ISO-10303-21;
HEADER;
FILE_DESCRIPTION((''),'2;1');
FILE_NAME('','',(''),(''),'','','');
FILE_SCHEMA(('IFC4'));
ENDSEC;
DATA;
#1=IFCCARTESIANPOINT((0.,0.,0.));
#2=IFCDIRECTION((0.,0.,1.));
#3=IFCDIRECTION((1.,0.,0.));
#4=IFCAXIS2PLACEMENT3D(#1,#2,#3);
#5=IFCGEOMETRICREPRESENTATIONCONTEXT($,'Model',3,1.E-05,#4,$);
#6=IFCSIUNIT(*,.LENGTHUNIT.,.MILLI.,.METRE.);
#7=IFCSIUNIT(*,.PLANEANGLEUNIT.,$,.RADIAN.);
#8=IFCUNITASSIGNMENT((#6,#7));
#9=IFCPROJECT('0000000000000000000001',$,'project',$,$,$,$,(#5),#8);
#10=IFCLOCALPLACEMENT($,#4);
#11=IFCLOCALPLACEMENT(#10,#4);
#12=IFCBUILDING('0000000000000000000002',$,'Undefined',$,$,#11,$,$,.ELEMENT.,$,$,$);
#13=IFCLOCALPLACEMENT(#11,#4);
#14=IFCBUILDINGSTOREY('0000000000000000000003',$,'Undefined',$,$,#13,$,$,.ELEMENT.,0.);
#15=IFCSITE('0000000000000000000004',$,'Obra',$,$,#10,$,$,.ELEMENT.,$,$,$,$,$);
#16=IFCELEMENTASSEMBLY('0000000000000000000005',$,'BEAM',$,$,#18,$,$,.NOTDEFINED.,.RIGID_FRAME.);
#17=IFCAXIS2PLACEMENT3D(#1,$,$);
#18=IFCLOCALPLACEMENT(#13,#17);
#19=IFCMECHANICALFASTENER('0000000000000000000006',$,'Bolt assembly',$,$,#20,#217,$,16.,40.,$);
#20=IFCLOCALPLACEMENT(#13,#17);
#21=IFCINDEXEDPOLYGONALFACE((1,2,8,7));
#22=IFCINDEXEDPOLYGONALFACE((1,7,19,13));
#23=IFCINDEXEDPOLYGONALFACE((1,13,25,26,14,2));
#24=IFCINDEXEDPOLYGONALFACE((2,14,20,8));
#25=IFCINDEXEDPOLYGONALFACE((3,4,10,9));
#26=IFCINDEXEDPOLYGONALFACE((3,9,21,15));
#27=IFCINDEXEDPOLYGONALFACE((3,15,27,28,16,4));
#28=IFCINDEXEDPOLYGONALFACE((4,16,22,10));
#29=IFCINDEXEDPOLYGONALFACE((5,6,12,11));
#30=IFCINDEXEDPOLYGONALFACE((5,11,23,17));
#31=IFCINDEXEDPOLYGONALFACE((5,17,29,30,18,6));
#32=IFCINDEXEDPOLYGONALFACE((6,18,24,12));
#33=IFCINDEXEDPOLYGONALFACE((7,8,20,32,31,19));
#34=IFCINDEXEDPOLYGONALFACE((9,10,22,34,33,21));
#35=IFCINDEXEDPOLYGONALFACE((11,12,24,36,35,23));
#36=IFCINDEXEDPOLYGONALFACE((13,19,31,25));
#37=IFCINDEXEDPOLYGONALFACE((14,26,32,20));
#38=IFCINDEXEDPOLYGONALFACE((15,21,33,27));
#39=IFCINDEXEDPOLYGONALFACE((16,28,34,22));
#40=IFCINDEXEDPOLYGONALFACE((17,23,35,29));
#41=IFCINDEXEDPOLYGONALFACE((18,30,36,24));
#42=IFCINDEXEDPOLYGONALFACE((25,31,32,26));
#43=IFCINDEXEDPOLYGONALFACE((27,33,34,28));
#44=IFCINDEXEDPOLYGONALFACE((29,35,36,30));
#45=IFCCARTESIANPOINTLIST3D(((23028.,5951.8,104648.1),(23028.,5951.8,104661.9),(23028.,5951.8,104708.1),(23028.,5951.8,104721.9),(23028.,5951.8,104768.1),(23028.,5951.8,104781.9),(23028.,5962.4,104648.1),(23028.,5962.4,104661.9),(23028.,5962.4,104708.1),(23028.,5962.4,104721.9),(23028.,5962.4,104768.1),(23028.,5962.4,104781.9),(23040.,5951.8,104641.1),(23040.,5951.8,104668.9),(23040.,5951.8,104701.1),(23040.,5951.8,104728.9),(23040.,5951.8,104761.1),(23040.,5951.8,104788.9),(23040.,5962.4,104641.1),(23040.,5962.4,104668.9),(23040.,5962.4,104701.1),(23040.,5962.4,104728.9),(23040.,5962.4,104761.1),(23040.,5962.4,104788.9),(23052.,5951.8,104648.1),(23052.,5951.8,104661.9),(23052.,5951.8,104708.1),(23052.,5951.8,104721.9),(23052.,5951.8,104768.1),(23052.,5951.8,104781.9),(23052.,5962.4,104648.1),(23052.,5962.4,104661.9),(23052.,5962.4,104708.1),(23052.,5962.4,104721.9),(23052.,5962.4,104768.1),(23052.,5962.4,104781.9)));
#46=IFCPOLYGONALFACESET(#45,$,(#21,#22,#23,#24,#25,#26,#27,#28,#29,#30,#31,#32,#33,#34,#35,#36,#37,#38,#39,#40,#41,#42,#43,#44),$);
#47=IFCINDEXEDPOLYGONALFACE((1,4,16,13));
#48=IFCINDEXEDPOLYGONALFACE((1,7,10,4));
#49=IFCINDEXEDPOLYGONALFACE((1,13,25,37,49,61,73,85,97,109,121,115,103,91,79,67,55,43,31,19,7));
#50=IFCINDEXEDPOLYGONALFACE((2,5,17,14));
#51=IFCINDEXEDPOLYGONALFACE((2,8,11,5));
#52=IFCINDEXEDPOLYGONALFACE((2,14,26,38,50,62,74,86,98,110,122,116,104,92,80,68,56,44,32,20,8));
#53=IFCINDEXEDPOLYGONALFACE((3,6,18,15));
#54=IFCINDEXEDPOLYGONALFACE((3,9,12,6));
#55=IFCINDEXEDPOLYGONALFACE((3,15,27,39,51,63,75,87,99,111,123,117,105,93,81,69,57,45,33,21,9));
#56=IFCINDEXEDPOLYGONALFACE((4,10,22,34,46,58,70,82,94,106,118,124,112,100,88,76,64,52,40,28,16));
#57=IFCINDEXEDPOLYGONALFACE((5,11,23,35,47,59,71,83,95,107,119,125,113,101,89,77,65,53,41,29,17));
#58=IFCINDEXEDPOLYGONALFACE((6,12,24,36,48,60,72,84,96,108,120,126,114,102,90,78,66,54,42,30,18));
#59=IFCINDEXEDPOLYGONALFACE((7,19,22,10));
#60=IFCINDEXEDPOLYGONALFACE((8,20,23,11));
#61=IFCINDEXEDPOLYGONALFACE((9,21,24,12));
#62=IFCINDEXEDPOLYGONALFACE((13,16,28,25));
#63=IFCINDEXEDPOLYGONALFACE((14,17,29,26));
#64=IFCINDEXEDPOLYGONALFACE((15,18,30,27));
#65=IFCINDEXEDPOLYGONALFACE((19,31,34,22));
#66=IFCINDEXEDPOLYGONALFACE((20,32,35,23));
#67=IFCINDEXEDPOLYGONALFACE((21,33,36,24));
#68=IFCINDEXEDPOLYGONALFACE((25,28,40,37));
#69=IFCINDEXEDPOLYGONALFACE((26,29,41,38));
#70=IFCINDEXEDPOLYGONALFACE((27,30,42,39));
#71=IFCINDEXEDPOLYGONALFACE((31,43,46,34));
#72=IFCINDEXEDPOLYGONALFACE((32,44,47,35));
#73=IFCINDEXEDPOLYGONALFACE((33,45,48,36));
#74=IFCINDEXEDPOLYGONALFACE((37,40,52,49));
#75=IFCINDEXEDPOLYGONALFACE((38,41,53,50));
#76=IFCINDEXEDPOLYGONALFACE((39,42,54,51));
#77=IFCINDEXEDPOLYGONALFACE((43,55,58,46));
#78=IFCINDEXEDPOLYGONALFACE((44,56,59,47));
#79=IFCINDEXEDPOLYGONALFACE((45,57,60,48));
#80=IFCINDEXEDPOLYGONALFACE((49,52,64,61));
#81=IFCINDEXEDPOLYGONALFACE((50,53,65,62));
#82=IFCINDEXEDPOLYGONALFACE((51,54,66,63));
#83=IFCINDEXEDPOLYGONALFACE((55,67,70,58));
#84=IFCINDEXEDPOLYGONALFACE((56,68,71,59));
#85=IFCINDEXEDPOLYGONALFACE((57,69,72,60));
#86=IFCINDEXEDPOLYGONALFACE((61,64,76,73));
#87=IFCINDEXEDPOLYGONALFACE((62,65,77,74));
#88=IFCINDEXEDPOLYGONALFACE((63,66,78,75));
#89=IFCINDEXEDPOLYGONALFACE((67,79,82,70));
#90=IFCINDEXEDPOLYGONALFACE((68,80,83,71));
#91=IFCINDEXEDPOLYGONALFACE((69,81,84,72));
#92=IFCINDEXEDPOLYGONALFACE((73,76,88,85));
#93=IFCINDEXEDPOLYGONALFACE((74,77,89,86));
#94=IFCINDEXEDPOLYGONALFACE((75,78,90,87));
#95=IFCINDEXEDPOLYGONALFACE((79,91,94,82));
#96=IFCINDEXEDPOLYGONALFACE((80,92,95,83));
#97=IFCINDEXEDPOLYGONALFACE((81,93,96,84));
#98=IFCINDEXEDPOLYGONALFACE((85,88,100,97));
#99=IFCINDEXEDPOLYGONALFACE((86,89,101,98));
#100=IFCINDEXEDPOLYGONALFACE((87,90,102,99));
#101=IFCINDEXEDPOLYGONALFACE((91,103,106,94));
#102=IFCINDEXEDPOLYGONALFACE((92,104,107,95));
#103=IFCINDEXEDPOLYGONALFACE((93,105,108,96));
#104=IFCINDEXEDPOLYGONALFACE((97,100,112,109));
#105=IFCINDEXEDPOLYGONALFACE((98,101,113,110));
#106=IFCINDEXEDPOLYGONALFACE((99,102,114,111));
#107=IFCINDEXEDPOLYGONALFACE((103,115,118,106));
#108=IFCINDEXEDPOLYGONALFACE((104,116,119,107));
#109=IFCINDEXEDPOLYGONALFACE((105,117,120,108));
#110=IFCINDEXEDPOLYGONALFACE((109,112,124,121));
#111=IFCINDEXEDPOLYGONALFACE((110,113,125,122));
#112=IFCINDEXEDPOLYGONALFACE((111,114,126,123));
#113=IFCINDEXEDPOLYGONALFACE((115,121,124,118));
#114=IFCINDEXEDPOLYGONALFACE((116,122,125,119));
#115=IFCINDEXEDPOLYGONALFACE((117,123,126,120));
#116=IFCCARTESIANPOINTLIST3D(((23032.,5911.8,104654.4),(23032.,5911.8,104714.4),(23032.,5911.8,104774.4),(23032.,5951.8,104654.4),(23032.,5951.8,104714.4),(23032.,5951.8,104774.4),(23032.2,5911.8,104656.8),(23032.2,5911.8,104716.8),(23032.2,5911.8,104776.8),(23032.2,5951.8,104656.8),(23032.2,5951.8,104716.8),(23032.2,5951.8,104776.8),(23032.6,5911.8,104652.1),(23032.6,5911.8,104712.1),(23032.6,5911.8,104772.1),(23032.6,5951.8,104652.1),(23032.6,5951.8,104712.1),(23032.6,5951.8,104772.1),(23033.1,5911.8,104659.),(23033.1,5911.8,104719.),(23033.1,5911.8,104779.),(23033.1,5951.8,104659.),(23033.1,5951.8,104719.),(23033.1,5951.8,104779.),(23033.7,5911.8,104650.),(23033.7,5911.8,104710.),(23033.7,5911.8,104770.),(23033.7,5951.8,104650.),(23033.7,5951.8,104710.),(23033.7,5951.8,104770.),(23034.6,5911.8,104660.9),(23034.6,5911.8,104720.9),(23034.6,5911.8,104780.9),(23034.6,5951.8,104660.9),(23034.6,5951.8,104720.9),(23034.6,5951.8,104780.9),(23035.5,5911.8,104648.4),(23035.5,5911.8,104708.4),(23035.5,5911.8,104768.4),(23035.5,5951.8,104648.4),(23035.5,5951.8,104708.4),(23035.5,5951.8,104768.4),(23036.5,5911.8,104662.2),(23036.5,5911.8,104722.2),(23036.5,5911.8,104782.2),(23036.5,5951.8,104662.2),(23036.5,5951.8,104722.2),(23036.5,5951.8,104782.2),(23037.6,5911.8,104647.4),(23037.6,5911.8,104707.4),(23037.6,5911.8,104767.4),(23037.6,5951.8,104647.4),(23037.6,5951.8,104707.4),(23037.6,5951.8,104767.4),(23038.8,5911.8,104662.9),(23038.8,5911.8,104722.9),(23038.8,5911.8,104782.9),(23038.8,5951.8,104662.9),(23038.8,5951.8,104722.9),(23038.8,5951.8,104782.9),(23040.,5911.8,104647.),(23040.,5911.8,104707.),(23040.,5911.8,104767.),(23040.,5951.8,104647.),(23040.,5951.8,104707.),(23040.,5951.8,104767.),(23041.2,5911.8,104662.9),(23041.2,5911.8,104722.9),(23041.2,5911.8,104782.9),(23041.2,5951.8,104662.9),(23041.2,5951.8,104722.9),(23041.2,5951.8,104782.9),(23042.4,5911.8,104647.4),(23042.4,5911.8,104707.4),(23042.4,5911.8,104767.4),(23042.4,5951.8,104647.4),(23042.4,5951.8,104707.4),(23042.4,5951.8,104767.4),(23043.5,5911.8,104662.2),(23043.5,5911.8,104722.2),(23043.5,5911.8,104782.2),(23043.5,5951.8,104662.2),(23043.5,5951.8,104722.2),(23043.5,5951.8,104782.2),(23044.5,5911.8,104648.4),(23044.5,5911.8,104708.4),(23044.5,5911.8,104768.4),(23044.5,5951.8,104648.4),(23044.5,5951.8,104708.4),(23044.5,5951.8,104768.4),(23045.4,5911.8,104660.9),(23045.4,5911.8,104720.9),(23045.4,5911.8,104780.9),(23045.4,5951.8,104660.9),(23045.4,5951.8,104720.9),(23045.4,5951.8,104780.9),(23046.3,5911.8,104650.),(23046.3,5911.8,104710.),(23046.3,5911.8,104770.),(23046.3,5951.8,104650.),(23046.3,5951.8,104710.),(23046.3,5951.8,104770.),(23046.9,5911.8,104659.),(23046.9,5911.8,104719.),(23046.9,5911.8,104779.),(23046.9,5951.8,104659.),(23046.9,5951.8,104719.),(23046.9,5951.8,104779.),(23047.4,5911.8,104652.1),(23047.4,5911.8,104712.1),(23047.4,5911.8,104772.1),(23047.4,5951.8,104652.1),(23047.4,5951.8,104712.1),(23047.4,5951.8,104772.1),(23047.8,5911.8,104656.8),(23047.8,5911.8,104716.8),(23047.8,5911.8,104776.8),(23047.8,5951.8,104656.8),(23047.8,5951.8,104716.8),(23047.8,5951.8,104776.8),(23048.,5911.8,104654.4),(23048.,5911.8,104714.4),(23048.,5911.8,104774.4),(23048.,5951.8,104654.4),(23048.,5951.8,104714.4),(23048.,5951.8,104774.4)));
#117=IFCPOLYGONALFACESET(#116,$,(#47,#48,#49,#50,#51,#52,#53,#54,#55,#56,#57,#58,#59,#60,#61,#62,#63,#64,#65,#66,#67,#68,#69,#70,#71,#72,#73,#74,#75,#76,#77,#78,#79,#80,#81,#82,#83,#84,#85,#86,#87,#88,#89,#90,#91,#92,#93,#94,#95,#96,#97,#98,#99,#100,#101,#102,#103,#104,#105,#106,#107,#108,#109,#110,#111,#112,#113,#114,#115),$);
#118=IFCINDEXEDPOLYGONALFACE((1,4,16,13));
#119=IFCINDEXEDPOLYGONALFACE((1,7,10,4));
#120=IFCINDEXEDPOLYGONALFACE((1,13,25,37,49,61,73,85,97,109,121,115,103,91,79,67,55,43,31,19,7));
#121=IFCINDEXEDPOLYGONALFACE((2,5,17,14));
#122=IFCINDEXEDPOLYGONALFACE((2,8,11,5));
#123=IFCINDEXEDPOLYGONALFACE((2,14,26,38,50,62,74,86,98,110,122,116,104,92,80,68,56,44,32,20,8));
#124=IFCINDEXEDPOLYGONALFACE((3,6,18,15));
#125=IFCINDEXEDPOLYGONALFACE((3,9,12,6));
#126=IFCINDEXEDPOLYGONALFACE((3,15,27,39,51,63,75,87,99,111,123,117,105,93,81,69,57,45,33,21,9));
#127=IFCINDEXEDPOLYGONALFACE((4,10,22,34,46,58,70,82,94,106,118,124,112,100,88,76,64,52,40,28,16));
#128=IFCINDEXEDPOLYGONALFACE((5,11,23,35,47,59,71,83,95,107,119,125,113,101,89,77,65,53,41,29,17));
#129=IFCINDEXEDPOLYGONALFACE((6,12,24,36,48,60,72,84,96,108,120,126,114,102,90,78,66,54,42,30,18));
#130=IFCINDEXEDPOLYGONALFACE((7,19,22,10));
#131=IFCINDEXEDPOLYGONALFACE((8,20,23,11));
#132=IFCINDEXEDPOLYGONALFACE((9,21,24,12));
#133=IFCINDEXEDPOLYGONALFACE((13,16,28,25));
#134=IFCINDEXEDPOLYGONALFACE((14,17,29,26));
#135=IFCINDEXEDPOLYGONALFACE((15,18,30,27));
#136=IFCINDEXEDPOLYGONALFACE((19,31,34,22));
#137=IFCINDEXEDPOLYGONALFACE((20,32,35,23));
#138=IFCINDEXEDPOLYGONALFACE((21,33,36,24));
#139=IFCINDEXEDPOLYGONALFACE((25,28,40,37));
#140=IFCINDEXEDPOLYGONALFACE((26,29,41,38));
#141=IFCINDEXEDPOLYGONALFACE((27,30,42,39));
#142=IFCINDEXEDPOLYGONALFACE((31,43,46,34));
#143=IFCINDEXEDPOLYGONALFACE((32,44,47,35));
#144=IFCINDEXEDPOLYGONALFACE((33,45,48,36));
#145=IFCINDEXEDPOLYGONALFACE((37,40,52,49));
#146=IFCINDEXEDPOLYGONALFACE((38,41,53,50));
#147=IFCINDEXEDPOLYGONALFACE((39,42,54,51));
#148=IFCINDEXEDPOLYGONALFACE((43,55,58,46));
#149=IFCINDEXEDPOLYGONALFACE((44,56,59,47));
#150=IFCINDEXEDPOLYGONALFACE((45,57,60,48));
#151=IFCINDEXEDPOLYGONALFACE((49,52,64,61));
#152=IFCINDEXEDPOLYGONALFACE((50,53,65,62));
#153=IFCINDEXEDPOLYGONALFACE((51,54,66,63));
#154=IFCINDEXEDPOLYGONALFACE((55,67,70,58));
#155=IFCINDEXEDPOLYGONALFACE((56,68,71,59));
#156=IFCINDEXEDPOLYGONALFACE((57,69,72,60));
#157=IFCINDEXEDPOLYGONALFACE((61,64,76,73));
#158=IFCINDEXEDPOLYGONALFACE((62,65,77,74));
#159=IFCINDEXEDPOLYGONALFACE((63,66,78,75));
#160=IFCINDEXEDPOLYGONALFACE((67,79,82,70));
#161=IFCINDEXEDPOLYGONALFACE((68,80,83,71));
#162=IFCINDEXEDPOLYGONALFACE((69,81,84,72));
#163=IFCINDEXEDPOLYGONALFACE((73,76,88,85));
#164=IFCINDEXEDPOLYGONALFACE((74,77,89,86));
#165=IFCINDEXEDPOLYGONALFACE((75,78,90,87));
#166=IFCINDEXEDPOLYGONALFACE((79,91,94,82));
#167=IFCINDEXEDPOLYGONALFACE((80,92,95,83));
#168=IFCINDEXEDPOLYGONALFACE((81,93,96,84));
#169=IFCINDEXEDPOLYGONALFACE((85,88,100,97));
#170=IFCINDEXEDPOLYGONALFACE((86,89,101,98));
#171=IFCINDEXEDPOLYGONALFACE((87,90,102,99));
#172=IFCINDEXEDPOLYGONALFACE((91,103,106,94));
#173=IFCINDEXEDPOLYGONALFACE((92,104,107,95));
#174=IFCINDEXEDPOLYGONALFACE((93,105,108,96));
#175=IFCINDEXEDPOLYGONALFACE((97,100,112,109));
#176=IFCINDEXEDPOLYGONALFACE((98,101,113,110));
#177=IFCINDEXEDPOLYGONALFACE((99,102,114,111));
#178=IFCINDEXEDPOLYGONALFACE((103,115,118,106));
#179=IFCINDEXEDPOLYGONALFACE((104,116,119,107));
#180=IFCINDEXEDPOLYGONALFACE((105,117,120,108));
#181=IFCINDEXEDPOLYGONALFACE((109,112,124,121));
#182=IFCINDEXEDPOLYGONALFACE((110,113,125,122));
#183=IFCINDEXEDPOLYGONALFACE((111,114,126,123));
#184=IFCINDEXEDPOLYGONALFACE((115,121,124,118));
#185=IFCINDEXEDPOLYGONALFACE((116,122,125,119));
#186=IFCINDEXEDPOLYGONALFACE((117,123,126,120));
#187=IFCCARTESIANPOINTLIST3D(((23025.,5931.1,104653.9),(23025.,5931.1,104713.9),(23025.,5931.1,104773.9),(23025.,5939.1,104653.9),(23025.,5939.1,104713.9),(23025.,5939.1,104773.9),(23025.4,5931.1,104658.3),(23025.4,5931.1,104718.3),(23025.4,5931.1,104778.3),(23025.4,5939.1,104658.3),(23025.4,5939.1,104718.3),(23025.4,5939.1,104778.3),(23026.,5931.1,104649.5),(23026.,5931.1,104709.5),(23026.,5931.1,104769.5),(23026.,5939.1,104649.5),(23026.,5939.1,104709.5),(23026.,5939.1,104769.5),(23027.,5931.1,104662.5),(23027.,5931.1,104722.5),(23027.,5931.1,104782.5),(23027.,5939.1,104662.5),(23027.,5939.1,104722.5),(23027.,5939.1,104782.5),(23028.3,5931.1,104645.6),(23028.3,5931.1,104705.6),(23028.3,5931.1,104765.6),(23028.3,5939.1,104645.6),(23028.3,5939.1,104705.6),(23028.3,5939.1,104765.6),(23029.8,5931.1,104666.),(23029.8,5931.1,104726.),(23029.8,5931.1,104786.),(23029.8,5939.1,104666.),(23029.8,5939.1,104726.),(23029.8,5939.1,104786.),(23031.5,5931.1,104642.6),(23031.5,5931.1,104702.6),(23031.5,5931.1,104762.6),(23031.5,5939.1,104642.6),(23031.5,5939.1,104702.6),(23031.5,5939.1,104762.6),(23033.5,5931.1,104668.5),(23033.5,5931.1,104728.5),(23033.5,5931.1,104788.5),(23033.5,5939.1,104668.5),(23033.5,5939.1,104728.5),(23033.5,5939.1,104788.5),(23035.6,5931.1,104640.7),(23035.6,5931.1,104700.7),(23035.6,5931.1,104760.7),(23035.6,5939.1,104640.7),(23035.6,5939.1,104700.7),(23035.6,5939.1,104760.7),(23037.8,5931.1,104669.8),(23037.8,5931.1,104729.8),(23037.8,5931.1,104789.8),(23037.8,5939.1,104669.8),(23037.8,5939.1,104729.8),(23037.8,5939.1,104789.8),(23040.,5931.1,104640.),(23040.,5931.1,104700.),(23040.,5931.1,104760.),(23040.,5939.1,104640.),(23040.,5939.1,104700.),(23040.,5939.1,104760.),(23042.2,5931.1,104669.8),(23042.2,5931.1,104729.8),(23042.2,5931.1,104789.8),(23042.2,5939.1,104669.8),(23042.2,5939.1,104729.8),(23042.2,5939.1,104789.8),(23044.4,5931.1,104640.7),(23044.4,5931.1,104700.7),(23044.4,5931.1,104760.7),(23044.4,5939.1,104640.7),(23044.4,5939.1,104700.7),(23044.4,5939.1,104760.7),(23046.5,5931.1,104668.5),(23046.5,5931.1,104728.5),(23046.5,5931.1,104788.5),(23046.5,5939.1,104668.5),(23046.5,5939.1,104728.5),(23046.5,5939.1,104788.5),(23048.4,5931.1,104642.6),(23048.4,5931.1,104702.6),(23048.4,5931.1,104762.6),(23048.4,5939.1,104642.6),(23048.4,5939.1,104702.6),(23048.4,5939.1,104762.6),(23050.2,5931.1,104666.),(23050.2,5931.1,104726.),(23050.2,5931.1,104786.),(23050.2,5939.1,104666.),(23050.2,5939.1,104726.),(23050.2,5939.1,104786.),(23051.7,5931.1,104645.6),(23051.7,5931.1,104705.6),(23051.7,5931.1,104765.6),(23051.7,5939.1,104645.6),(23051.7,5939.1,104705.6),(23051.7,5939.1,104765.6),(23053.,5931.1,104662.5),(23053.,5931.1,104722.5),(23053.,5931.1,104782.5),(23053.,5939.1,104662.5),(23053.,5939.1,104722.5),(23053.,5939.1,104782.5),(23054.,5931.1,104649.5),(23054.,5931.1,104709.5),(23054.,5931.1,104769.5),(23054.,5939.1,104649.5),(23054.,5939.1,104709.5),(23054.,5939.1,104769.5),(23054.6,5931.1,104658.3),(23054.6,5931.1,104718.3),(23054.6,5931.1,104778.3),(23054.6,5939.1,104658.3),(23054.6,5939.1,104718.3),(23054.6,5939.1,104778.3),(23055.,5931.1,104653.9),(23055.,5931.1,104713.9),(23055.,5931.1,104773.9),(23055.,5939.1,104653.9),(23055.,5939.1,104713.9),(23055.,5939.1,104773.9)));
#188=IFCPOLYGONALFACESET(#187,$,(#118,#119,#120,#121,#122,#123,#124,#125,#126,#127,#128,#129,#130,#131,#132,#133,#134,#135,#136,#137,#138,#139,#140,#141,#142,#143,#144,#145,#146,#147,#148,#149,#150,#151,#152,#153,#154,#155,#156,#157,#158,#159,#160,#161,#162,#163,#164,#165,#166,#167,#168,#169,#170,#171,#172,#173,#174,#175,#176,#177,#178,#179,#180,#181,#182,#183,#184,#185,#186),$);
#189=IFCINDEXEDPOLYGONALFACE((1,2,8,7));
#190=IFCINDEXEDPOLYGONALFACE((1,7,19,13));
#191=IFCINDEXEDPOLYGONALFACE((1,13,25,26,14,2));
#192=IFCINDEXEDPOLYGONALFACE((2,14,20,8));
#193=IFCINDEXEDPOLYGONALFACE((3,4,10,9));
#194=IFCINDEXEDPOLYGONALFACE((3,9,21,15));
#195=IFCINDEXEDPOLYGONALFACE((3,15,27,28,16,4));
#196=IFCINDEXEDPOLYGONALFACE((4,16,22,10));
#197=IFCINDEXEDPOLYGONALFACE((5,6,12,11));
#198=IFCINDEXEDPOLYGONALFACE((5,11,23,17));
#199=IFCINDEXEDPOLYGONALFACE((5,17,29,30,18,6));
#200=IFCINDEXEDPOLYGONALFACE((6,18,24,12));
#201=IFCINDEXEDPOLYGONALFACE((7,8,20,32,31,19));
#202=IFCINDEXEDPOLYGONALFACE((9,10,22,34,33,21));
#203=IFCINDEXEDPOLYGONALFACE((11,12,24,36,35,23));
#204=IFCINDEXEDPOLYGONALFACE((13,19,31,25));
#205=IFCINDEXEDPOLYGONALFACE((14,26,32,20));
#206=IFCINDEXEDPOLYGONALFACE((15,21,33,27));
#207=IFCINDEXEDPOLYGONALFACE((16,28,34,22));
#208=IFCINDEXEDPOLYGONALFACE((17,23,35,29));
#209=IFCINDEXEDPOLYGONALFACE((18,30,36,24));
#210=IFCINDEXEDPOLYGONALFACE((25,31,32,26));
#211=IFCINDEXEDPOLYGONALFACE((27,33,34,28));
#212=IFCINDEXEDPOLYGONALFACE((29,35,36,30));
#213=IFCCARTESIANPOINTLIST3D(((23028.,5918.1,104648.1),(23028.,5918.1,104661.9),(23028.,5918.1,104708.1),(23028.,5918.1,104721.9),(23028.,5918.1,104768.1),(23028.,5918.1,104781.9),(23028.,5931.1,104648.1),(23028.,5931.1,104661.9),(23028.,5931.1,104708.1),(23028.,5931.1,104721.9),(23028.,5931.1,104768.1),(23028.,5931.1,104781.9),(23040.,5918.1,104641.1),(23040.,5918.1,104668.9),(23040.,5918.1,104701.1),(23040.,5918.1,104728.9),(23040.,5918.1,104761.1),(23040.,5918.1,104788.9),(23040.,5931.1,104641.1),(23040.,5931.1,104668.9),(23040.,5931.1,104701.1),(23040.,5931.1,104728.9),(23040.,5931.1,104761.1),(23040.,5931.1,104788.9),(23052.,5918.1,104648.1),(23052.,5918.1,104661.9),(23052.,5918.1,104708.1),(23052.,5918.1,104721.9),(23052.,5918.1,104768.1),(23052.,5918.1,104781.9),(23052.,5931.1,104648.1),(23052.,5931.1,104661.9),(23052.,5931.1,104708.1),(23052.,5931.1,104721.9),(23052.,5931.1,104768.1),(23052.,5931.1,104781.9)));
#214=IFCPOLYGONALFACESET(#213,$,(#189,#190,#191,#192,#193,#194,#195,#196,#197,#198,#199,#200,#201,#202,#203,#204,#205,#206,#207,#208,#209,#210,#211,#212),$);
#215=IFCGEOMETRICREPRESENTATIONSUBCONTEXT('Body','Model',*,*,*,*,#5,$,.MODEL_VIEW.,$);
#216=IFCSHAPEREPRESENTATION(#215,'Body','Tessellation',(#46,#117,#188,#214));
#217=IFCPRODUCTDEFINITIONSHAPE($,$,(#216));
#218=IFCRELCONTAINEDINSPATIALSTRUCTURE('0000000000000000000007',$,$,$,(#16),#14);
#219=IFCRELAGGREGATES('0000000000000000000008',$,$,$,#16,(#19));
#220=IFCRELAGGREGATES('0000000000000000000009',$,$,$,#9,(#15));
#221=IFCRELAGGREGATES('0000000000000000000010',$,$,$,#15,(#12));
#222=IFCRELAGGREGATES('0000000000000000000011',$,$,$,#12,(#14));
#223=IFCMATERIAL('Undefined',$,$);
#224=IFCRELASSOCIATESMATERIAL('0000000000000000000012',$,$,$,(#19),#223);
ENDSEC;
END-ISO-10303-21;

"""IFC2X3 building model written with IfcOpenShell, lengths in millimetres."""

from ifc_helpers import new_model, si_unit, frame, origin_with_axes, origin_2d_with_axis, place, context, subcontext, project, spatial, polyline, circle, outline, extrude, source, transform, mapped, material, element, aggregate, save


model = new_model("IFC2X3")

# Units and contexts
model_context = context("Model", 3, precision=1e-05, world=origin_with_axes())
body_context = subcontext(model_context, "Body", "Model", "MODEL_VIEW")
ifc_project = project(units=[si_unit("LENGTHUNIT", "METRE", prefix="MILLI"), si_unit("PLANEANGLEUNIT", "RADIAN")], contexts=[model_context])

# Site, building, storey
site_placement = place(None, origin_with_axes())
site = spatial("IfcSite", under=ifc_project, at=site_placement, Name="Obra", CompositionType="ELEMENT")
building_placement = place(site_placement, origin_with_axes())
building = spatial("IfcBuilding", under=site, at=building_placement, Name="Undefined", CompositionType="ELEMENT")
storey_placement = place(building_placement, origin_with_axes())
storey = spatial("IfcBuildingStorey", under=building, at=storey_placement, Name="Undefined", CompositionType="ELEMENT", Elevation=0.0)

# Element assembly, mechanical fastener
assembly_1_placement = place(storey_placement, origin_with_axes())
assembly_1 = element("IfcElementAssembly", 1, at=assembly_1_placement, inside=storey, Name="BEAM", AssemblyPlace="NOTDEFINED", PredefinedType="RIGID_FRAME")
ifc_material_1 = material(Name="Undefined")
shared_shape_1 = source(origin_with_axes(), body_context, "Body", "SweptSolid", [
    extrude(outline(polyline([(13.9, 0.0), (6.9, 12.0), (-6.9, 12.0), (-13.9, 0.0), (-6.9, -12.0), (6.9, -12.0), (13.9, 0.0)])), frame((0.0, -19.7, 0.0), z_axis=(0.0, 1.0, 0.0), x_axis=(1.0, 0.0, 0.0)), (0.0, 0.0, 1.0), 10.6),
    extrude(circle(Radius=8.0, at=origin_2d_with_axis()), frame((0.0, -9.1, 0.0), z_axis=(0.0, 1.0, 0.0), x_axis=(1.0, 0.0, 0.0)), (0.0, 0.0, 1.0), 40.0),
    extrude(circle(Radius=15.0, at=origin_2d_with_axis()), frame((0.0, 3.6, 0.0), z_axis=(0.0, 1.0, 0.0), x_axis=(1.0, 0.0, 0.0)), (0.0, 0.0, 1.0), 8.0),
    extrude(outline(polyline([(13.9, 0.0), (6.9, 12.0), (-6.9, 12.0), (-13.9, 0.0), (-6.9, -12.0), (6.9, -12.0), (13.9, 0.0)])), frame((0.0, 11.6, 0.0), z_axis=(0.0, 1.0, 0.0), x_axis=(1.0, 0.0, 0.0)), (0.0, 0.0, 1.0), 13.0),
])
mechanical_fastener_1_placement = place(assembly_1_placement, frame((23090.0, 5942.7, 104835.0), z_axis=(-1.0, 0.0, 0.0), x_axis=(0.0, 0.0, -1.0)))
mechanical_fastener_1 = element("IfcMechanicalFastener", 2, at=mechanical_fastener_1_placement, material=ifc_material_1, Name="Bolt assembly", NominalDiameter=16.0, NominalLength=40.0, context=body_context, shape_type="MappedRepresentation", body=[
    mapped(shared_shape_1, transform((60.0, 0.0, 50.0))),
    mapped(shared_shape_1, transform((120.0, 0.0, 50.0))),
    mapped(shared_shape_1, transform((180.0, 0.0, 50.0))),
])

aggregate(assembly_1, [mechanical_fastener_1])

save(model, "model.ifc")
